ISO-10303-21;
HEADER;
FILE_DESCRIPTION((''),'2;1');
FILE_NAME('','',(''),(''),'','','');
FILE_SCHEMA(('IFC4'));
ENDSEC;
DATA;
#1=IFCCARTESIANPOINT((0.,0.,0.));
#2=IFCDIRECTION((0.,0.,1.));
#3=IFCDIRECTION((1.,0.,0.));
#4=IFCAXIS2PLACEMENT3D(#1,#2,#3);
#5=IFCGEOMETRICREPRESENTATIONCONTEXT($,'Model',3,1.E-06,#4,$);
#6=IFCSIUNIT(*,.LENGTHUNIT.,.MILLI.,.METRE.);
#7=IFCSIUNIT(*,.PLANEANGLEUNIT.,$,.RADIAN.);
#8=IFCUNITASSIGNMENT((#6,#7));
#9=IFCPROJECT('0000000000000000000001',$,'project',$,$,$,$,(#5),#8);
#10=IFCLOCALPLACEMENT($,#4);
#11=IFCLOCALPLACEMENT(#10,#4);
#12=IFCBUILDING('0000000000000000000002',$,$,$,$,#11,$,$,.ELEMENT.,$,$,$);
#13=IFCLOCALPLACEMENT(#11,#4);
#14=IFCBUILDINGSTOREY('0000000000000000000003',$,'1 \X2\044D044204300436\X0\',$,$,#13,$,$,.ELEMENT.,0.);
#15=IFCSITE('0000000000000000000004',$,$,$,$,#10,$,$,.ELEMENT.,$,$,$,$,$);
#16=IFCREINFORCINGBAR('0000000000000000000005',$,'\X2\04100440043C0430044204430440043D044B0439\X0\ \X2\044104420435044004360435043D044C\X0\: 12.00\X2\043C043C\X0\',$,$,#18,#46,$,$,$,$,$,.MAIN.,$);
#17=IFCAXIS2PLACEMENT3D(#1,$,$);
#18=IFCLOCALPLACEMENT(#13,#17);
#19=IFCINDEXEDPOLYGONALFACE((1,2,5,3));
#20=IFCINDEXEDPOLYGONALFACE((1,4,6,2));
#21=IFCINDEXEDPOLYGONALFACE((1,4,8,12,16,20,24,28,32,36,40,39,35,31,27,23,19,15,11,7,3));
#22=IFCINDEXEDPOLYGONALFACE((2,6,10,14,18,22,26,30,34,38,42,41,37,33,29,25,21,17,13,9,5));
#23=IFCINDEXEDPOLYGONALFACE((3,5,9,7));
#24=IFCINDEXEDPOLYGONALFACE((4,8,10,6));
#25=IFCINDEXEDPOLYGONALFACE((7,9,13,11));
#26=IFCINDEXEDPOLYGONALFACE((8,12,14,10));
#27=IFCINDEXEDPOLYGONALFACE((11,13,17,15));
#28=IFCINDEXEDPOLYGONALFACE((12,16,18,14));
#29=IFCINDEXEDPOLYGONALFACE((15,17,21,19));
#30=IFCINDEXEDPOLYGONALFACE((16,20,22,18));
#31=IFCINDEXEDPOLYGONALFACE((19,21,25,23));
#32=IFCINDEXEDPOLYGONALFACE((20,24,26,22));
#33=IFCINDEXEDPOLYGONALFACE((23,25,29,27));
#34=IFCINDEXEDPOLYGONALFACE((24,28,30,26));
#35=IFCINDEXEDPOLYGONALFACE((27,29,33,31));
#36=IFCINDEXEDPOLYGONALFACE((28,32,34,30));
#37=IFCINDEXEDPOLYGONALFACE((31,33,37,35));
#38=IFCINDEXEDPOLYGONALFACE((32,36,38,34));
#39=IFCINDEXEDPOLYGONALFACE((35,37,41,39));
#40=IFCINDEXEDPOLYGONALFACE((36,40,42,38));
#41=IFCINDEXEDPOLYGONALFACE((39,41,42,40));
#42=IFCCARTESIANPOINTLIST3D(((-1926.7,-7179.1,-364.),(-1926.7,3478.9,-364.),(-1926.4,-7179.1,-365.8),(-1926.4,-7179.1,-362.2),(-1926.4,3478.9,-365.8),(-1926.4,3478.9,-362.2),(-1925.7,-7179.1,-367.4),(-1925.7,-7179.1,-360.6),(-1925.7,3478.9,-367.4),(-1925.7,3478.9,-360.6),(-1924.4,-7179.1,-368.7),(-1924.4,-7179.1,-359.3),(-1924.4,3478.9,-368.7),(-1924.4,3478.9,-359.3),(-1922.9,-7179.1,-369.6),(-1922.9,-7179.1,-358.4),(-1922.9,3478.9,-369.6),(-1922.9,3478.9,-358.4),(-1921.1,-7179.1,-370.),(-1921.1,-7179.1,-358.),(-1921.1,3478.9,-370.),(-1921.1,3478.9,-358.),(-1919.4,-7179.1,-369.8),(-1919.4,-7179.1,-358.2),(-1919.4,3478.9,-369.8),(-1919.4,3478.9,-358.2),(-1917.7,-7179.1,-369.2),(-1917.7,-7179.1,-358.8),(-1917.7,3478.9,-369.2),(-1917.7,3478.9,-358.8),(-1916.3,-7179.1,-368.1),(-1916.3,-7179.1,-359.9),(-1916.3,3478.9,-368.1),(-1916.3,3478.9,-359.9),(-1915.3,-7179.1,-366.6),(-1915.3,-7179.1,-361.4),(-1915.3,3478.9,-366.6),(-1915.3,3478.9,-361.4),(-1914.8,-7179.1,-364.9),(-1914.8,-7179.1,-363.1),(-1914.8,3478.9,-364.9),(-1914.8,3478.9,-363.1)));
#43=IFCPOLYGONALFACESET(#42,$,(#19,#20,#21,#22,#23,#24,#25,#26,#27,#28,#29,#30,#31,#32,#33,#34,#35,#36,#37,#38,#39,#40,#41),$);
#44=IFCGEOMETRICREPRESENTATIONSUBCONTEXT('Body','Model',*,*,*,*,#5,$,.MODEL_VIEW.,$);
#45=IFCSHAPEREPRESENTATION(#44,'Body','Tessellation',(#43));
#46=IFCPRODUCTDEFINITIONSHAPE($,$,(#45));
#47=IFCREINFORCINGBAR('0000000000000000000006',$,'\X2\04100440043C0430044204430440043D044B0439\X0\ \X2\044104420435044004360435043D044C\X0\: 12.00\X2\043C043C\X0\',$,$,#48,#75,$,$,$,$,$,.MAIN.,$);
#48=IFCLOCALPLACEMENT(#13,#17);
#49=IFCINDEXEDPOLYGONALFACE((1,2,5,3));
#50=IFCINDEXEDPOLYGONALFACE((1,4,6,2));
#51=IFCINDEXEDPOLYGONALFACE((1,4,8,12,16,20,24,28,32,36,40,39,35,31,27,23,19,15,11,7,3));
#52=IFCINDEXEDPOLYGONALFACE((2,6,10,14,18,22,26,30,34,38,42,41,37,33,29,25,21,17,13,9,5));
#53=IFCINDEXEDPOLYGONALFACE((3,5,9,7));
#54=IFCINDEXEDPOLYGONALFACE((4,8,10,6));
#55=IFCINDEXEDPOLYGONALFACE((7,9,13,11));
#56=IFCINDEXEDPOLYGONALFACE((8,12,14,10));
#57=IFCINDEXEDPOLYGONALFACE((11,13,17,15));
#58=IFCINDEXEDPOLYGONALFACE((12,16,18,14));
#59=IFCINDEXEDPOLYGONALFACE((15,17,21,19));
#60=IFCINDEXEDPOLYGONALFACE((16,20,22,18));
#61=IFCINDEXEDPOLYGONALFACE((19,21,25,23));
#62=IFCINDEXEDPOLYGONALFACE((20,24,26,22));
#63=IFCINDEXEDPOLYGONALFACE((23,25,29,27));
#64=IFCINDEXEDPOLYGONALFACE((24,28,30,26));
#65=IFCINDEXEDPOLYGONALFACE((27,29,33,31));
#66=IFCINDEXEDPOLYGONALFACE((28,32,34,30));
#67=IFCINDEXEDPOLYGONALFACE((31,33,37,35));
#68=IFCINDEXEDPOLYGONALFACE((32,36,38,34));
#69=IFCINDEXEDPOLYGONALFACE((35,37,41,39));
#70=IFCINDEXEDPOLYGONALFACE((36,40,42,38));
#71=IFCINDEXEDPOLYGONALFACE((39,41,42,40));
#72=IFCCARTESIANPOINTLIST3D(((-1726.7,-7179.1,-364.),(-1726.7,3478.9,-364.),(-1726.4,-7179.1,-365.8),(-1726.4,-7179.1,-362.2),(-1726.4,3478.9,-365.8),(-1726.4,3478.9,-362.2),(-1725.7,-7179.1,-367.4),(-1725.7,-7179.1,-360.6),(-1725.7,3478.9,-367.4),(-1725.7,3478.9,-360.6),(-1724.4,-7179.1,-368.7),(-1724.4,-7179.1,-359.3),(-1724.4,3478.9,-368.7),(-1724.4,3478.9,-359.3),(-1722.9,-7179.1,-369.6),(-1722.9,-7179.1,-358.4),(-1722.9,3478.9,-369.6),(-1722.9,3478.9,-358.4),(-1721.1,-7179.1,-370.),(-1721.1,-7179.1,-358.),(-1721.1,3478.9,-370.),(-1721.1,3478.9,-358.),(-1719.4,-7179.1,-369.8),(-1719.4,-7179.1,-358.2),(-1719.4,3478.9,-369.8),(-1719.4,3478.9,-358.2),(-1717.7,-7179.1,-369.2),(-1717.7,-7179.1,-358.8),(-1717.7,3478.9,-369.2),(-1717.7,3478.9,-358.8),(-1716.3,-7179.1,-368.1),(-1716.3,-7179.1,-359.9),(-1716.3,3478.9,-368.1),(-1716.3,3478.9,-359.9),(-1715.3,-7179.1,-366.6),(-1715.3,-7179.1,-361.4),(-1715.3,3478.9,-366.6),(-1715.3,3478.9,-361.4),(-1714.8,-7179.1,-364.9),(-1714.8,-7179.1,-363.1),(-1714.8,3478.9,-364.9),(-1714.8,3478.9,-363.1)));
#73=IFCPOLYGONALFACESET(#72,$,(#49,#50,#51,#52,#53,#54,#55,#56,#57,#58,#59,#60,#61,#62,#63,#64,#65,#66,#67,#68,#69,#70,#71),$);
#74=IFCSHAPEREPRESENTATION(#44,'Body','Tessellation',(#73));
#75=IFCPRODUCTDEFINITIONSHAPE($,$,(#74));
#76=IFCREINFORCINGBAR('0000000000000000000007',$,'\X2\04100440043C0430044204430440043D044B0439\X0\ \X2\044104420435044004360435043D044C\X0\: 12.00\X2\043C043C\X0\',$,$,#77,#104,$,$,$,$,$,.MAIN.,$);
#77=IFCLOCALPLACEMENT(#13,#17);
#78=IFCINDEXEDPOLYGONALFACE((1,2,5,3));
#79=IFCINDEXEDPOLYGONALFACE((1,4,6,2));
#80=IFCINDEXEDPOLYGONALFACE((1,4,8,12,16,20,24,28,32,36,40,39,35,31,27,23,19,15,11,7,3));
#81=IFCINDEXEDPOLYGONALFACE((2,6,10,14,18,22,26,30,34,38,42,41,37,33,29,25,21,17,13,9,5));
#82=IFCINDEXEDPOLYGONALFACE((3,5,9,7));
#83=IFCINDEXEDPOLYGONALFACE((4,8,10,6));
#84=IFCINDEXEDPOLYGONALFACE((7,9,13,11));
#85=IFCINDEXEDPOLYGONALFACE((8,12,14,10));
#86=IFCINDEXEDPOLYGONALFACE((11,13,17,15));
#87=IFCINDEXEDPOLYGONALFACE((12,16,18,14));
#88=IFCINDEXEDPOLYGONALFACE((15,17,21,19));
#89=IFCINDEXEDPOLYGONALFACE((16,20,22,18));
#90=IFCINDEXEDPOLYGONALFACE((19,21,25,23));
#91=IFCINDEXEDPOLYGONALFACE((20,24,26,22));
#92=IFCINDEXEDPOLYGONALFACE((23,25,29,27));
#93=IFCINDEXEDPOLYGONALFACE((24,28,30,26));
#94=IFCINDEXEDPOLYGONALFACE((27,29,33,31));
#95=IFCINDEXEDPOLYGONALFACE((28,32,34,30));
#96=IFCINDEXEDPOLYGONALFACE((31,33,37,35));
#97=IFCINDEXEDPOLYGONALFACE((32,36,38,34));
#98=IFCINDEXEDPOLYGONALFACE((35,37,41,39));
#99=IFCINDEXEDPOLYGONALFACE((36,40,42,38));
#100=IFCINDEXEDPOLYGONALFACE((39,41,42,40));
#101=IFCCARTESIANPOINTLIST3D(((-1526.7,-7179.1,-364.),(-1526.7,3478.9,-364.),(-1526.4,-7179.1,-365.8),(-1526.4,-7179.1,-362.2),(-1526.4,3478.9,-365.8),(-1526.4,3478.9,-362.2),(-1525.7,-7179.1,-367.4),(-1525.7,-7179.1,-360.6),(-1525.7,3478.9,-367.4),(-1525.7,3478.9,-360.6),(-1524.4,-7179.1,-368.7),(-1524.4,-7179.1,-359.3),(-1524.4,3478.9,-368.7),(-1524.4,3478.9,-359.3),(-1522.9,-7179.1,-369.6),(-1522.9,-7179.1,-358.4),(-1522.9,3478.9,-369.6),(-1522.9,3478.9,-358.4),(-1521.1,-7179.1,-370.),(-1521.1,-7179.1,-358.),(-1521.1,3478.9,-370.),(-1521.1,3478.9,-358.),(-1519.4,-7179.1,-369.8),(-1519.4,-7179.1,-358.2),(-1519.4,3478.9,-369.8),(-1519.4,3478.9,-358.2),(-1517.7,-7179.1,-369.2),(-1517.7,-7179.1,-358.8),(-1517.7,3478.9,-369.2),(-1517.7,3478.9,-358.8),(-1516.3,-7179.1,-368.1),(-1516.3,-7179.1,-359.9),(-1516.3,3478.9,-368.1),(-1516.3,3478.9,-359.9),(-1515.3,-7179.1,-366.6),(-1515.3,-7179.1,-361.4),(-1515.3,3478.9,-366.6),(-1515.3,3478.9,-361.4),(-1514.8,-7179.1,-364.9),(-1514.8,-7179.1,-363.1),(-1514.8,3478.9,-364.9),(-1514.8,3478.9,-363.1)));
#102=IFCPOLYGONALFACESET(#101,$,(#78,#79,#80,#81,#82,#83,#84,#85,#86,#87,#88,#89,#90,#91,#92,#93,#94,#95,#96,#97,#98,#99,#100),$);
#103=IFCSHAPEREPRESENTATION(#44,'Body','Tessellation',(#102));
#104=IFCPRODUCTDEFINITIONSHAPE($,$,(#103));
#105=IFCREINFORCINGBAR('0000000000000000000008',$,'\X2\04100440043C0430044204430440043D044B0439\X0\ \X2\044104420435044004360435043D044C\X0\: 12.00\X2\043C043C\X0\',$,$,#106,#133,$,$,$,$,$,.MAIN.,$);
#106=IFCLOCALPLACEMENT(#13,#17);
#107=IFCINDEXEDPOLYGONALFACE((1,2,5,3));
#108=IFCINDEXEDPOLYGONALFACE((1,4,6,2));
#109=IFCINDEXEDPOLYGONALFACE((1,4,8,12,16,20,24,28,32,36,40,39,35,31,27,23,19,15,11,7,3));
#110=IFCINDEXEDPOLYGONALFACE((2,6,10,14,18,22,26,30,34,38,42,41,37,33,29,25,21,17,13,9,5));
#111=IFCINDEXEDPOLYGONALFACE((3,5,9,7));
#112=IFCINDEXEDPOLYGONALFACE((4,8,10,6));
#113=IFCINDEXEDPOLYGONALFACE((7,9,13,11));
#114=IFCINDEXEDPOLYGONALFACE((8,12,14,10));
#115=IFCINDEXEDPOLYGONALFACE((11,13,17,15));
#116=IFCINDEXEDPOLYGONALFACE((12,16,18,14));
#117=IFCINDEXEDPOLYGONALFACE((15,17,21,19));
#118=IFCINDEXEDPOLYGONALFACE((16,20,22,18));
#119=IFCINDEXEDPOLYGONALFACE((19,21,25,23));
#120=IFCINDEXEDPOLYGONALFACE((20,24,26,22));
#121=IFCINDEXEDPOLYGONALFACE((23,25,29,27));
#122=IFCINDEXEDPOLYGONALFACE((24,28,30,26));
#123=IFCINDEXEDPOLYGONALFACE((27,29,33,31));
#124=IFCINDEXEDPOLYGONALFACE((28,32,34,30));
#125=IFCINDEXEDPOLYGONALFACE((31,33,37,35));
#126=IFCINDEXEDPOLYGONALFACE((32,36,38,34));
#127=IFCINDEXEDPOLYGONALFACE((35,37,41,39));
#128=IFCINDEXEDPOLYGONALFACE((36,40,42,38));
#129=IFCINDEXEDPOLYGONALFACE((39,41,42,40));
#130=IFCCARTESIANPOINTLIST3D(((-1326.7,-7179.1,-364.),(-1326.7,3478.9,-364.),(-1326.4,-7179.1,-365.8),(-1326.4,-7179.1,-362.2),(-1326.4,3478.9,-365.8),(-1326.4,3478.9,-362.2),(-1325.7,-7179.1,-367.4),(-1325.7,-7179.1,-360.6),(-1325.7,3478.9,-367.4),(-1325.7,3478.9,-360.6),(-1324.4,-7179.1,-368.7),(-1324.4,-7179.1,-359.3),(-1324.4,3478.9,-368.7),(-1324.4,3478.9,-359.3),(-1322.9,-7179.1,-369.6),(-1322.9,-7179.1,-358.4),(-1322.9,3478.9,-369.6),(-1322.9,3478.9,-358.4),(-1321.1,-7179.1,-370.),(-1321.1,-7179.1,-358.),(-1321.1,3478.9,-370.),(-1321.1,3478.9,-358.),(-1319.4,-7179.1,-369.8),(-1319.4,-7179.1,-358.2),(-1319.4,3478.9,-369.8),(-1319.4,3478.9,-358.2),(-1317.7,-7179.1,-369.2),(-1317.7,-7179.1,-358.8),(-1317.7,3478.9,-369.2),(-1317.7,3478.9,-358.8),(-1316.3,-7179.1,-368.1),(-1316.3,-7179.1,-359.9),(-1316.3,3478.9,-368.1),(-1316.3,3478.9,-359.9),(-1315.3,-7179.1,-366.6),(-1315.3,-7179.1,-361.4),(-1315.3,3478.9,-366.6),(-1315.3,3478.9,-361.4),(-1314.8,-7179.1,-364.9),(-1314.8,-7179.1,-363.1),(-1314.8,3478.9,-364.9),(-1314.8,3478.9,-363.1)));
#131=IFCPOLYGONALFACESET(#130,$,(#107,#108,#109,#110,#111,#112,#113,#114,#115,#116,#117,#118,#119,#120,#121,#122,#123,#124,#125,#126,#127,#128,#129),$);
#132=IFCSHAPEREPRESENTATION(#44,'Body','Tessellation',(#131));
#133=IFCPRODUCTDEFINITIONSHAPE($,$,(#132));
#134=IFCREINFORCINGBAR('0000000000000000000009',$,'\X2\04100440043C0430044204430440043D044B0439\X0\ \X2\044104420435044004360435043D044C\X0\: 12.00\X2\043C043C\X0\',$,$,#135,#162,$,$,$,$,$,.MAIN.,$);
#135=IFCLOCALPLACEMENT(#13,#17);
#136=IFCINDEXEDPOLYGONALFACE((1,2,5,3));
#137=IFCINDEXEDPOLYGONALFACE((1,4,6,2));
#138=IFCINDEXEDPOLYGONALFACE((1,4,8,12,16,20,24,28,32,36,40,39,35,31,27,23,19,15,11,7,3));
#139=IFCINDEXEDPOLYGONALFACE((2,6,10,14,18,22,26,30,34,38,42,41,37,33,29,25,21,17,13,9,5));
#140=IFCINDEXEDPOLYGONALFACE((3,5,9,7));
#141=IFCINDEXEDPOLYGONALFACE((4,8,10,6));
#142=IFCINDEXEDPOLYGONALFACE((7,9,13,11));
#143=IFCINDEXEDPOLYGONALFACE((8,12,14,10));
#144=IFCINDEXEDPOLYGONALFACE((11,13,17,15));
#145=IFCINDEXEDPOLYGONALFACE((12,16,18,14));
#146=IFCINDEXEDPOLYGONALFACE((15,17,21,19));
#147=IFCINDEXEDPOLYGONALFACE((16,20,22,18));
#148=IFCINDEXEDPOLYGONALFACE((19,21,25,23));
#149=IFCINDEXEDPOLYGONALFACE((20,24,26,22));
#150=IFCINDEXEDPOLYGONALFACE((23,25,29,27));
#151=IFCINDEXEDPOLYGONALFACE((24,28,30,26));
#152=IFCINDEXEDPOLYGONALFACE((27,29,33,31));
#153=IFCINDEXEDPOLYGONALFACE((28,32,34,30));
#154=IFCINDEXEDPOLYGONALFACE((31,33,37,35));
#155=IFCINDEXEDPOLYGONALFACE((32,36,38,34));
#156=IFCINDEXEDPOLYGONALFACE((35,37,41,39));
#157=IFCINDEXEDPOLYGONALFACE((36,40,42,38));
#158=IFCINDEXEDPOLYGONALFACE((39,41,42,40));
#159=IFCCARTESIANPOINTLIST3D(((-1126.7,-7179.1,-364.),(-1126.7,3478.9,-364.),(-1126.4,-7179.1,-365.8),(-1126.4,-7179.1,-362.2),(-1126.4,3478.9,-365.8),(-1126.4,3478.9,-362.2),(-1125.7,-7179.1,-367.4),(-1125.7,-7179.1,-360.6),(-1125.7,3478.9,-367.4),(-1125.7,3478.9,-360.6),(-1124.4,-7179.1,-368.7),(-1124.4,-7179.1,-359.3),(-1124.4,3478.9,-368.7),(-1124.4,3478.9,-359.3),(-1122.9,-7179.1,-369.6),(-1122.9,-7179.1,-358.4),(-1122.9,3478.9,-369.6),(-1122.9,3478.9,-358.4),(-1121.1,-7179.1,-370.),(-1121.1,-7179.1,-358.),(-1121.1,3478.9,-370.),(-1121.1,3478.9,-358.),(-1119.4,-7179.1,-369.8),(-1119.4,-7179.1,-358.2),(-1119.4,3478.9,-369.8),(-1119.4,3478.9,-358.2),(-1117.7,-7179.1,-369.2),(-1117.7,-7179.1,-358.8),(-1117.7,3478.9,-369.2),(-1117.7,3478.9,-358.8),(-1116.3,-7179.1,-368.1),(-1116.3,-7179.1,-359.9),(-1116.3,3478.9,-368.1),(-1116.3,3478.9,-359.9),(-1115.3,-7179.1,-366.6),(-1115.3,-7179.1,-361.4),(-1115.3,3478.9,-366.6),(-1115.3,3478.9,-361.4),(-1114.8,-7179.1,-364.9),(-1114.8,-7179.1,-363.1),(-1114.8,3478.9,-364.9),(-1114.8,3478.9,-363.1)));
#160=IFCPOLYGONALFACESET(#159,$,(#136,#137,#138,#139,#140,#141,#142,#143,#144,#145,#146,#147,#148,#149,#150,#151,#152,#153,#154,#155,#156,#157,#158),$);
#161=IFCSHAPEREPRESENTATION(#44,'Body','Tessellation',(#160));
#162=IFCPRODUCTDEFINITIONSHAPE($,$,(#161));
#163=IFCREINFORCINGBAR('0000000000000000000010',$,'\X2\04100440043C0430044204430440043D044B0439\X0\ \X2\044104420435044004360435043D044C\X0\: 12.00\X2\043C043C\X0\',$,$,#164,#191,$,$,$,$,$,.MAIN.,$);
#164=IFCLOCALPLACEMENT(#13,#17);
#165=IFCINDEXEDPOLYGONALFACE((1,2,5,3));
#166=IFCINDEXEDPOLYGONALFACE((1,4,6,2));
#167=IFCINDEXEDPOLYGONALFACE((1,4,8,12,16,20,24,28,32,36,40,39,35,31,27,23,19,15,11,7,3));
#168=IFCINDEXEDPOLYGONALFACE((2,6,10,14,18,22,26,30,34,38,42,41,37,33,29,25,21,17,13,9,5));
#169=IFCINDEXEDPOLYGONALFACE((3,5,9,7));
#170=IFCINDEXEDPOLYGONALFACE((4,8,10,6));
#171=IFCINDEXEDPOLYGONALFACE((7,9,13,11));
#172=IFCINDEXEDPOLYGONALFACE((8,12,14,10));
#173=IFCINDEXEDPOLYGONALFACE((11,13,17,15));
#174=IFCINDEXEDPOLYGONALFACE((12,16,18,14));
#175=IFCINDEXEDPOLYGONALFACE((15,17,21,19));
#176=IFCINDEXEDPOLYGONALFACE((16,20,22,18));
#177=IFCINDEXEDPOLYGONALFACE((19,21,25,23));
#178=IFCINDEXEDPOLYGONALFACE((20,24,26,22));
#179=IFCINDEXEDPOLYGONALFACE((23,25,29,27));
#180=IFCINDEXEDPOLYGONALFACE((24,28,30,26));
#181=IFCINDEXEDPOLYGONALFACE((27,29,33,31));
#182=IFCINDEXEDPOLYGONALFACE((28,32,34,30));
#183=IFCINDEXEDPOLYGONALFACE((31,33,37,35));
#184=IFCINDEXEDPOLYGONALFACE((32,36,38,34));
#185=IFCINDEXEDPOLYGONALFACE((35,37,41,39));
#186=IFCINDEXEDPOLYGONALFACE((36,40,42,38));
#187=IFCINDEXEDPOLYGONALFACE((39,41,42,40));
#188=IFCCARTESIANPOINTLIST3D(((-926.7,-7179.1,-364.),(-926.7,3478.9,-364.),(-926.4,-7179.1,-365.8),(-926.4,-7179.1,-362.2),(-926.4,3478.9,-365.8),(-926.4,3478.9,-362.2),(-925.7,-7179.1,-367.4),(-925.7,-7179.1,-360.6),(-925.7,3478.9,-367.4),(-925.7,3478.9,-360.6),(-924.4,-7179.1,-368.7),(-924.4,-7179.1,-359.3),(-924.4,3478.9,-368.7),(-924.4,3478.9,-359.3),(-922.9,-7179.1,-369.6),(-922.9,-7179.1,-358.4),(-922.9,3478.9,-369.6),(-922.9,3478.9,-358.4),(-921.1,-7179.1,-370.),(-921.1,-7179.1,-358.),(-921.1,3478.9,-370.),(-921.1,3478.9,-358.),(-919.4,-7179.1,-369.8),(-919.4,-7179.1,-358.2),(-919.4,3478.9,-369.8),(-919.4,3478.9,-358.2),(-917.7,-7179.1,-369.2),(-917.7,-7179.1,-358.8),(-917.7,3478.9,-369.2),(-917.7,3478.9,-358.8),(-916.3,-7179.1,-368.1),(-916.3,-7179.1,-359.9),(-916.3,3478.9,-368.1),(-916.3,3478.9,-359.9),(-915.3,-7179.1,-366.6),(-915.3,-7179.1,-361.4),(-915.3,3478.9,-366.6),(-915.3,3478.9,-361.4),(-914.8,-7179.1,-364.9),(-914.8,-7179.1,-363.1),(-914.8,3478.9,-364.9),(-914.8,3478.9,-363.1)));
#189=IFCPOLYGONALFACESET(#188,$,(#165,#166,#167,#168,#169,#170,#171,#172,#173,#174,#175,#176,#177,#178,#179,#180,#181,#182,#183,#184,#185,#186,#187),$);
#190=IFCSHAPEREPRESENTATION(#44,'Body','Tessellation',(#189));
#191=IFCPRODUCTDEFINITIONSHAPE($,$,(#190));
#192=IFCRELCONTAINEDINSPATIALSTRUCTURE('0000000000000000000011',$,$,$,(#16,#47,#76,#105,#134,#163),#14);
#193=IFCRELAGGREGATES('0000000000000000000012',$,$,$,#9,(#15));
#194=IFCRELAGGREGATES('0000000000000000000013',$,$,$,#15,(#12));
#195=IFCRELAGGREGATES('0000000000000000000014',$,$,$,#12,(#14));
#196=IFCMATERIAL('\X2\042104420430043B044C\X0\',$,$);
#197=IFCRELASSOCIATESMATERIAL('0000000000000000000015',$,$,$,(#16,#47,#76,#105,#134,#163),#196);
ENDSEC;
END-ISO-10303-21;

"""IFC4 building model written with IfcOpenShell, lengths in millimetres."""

from ifc_helpers import new_model, entity, si_unit, origin_with_axes, place, context, subcontext, project, spatial, source, transform, mapped, material, element, save


model = new_model("IFC4")

# Units and contexts
model_context = context("Model", 3, precision=1e-06, world=origin_with_axes())
body_context = subcontext(model_context, "Body", "Model", "MODEL_VIEW")
ifc_project = project(units=[si_unit("LENGTHUNIT", "METRE", prefix="MILLI"), si_unit("PLANEANGLEUNIT", "RADIAN")], contexts=[model_context])

# Site, building, storey
site_placement = place(None, origin_with_axes())
site = spatial("IfcSite", under=ifc_project, at=site_placement, CompositionType="ELEMENT")
building_placement = place(site_placement, origin_with_axes())
building = spatial("IfcBuilding", under=site, at=building_placement, CompositionType="ELEMENT")
storey_placement = place(building_placement, origin_with_axes())
storey = spatial("IfcBuildingStorey", under=building, at=storey_placement, Name="1 этаж", CompositionType="ELEMENT", Elevation=0.0)

# Reinforcing bars
ifc_material = material(Name="Сталь")
shared_shape_1 = source(origin_with_axes(), body_context, "Body", "AdvancedSweptSolid", [
    entity("IfcSweptDiskSolid", entity("IfcIndexedPolyCurve", entity("IfcCartesianPointList3D", [[0.0, 0.0, 0.0], [10658.0, 0.0, 0.0]]), [entity("IfcLineIndex", [1, 2])]), 6.0),
])
reinforcing_bar_1_placement = place(storey_placement, origin_with_axes())
element("IfcReinforcingBar", 1, at=reinforcing_bar_1_placement, inside=storey, material=ifc_material, Name="Арматурный стержень: 12.00мм", PredefinedType="MAIN", context=body_context, shape_type="MappedRepresentation", body=[
    mapped(shared_shape_1, transform((-1920.7, -7179.1, -364.0), x_axis=(0.0, 1.0, 0.0), y_axis=(-1.0, 0.0, 0.0), z_axis=(0.0, 0.0, 1.0), scale=1.0)),
])
reinforcing_bar_2_placement = place(storey_placement, origin_with_axes())
element("IfcReinforcingBar", 2, at=reinforcing_bar_2_placement, inside=storey, material=ifc_material, Name="Арматурный стержень: 12.00мм", PredefinedType="MAIN", context=body_context, shape_type="MappedRepresentation", body=[
    mapped(shared_shape_1, transform((-1720.7, -7179.1, -364.0), x_axis=(0.0, 1.0, 0.0), y_axis=(-1.0, 0.0, 0.0), z_axis=(0.0, 0.0, 1.0), scale=1.0)),
])
reinforcing_bar_3_placement = place(storey_placement, origin_with_axes())
element("IfcReinforcingBar", 3, at=reinforcing_bar_3_placement, inside=storey, material=ifc_material, Name="Арматурный стержень: 12.00мм", PredefinedType="MAIN", context=body_context, shape_type="MappedRepresentation", body=[
    mapped(shared_shape_1, transform((-1520.7, -7179.1, -364.0), x_axis=(0.0, 1.0, 0.0), y_axis=(-1.0, 0.0, 0.0), z_axis=(0.0, 0.0, 1.0), scale=1.0)),
])
reinforcing_bar_4_placement = place(storey_placement, origin_with_axes())
element("IfcReinforcingBar", 4, at=reinforcing_bar_4_placement, inside=storey, material=ifc_material, Name="Арматурный стержень: 12.00мм", PredefinedType="MAIN", context=body_context, shape_type="MappedRepresentation", body=[
    mapped(shared_shape_1, transform((-1320.7, -7179.1, -364.0), x_axis=(0.0, 1.0, 0.0), y_axis=(-1.0, 0.0, 0.0), z_axis=(0.0, 0.0, 1.0), scale=1.0)),
])
reinforcing_bar_5_placement = place(storey_placement, origin_with_axes())
element("IfcReinforcingBar", 5, at=reinforcing_bar_5_placement, inside=storey, material=ifc_material, Name="Арматурный стержень: 12.00мм", PredefinedType="MAIN", context=body_context, shape_type="MappedRepresentation", body=[
    mapped(shared_shape_1, transform((-1120.7, -7179.1, -364.0), x_axis=(0.0, 1.0, 0.0), y_axis=(-1.0, 0.0, 0.0), z_axis=(0.0, 0.0, 1.0), scale=1.0)),
])
reinforcing_bar_6_placement = place(storey_placement, origin_with_axes())
element("IfcReinforcingBar", 6, at=reinforcing_bar_6_placement, inside=storey, material=ifc_material, Name="Арматурный стержень: 12.00мм", PredefinedType="MAIN", context=body_context, shape_type="MappedRepresentation", body=[
    mapped(shared_shape_1, transform((-920.7, -7179.1, -364.0), x_axis=(0.0, 1.0, 0.0), y_axis=(-1.0, 0.0, 0.0), z_axis=(0.0, 0.0, 1.0), scale=1.0)),
])

save(model, "model.ifc")
